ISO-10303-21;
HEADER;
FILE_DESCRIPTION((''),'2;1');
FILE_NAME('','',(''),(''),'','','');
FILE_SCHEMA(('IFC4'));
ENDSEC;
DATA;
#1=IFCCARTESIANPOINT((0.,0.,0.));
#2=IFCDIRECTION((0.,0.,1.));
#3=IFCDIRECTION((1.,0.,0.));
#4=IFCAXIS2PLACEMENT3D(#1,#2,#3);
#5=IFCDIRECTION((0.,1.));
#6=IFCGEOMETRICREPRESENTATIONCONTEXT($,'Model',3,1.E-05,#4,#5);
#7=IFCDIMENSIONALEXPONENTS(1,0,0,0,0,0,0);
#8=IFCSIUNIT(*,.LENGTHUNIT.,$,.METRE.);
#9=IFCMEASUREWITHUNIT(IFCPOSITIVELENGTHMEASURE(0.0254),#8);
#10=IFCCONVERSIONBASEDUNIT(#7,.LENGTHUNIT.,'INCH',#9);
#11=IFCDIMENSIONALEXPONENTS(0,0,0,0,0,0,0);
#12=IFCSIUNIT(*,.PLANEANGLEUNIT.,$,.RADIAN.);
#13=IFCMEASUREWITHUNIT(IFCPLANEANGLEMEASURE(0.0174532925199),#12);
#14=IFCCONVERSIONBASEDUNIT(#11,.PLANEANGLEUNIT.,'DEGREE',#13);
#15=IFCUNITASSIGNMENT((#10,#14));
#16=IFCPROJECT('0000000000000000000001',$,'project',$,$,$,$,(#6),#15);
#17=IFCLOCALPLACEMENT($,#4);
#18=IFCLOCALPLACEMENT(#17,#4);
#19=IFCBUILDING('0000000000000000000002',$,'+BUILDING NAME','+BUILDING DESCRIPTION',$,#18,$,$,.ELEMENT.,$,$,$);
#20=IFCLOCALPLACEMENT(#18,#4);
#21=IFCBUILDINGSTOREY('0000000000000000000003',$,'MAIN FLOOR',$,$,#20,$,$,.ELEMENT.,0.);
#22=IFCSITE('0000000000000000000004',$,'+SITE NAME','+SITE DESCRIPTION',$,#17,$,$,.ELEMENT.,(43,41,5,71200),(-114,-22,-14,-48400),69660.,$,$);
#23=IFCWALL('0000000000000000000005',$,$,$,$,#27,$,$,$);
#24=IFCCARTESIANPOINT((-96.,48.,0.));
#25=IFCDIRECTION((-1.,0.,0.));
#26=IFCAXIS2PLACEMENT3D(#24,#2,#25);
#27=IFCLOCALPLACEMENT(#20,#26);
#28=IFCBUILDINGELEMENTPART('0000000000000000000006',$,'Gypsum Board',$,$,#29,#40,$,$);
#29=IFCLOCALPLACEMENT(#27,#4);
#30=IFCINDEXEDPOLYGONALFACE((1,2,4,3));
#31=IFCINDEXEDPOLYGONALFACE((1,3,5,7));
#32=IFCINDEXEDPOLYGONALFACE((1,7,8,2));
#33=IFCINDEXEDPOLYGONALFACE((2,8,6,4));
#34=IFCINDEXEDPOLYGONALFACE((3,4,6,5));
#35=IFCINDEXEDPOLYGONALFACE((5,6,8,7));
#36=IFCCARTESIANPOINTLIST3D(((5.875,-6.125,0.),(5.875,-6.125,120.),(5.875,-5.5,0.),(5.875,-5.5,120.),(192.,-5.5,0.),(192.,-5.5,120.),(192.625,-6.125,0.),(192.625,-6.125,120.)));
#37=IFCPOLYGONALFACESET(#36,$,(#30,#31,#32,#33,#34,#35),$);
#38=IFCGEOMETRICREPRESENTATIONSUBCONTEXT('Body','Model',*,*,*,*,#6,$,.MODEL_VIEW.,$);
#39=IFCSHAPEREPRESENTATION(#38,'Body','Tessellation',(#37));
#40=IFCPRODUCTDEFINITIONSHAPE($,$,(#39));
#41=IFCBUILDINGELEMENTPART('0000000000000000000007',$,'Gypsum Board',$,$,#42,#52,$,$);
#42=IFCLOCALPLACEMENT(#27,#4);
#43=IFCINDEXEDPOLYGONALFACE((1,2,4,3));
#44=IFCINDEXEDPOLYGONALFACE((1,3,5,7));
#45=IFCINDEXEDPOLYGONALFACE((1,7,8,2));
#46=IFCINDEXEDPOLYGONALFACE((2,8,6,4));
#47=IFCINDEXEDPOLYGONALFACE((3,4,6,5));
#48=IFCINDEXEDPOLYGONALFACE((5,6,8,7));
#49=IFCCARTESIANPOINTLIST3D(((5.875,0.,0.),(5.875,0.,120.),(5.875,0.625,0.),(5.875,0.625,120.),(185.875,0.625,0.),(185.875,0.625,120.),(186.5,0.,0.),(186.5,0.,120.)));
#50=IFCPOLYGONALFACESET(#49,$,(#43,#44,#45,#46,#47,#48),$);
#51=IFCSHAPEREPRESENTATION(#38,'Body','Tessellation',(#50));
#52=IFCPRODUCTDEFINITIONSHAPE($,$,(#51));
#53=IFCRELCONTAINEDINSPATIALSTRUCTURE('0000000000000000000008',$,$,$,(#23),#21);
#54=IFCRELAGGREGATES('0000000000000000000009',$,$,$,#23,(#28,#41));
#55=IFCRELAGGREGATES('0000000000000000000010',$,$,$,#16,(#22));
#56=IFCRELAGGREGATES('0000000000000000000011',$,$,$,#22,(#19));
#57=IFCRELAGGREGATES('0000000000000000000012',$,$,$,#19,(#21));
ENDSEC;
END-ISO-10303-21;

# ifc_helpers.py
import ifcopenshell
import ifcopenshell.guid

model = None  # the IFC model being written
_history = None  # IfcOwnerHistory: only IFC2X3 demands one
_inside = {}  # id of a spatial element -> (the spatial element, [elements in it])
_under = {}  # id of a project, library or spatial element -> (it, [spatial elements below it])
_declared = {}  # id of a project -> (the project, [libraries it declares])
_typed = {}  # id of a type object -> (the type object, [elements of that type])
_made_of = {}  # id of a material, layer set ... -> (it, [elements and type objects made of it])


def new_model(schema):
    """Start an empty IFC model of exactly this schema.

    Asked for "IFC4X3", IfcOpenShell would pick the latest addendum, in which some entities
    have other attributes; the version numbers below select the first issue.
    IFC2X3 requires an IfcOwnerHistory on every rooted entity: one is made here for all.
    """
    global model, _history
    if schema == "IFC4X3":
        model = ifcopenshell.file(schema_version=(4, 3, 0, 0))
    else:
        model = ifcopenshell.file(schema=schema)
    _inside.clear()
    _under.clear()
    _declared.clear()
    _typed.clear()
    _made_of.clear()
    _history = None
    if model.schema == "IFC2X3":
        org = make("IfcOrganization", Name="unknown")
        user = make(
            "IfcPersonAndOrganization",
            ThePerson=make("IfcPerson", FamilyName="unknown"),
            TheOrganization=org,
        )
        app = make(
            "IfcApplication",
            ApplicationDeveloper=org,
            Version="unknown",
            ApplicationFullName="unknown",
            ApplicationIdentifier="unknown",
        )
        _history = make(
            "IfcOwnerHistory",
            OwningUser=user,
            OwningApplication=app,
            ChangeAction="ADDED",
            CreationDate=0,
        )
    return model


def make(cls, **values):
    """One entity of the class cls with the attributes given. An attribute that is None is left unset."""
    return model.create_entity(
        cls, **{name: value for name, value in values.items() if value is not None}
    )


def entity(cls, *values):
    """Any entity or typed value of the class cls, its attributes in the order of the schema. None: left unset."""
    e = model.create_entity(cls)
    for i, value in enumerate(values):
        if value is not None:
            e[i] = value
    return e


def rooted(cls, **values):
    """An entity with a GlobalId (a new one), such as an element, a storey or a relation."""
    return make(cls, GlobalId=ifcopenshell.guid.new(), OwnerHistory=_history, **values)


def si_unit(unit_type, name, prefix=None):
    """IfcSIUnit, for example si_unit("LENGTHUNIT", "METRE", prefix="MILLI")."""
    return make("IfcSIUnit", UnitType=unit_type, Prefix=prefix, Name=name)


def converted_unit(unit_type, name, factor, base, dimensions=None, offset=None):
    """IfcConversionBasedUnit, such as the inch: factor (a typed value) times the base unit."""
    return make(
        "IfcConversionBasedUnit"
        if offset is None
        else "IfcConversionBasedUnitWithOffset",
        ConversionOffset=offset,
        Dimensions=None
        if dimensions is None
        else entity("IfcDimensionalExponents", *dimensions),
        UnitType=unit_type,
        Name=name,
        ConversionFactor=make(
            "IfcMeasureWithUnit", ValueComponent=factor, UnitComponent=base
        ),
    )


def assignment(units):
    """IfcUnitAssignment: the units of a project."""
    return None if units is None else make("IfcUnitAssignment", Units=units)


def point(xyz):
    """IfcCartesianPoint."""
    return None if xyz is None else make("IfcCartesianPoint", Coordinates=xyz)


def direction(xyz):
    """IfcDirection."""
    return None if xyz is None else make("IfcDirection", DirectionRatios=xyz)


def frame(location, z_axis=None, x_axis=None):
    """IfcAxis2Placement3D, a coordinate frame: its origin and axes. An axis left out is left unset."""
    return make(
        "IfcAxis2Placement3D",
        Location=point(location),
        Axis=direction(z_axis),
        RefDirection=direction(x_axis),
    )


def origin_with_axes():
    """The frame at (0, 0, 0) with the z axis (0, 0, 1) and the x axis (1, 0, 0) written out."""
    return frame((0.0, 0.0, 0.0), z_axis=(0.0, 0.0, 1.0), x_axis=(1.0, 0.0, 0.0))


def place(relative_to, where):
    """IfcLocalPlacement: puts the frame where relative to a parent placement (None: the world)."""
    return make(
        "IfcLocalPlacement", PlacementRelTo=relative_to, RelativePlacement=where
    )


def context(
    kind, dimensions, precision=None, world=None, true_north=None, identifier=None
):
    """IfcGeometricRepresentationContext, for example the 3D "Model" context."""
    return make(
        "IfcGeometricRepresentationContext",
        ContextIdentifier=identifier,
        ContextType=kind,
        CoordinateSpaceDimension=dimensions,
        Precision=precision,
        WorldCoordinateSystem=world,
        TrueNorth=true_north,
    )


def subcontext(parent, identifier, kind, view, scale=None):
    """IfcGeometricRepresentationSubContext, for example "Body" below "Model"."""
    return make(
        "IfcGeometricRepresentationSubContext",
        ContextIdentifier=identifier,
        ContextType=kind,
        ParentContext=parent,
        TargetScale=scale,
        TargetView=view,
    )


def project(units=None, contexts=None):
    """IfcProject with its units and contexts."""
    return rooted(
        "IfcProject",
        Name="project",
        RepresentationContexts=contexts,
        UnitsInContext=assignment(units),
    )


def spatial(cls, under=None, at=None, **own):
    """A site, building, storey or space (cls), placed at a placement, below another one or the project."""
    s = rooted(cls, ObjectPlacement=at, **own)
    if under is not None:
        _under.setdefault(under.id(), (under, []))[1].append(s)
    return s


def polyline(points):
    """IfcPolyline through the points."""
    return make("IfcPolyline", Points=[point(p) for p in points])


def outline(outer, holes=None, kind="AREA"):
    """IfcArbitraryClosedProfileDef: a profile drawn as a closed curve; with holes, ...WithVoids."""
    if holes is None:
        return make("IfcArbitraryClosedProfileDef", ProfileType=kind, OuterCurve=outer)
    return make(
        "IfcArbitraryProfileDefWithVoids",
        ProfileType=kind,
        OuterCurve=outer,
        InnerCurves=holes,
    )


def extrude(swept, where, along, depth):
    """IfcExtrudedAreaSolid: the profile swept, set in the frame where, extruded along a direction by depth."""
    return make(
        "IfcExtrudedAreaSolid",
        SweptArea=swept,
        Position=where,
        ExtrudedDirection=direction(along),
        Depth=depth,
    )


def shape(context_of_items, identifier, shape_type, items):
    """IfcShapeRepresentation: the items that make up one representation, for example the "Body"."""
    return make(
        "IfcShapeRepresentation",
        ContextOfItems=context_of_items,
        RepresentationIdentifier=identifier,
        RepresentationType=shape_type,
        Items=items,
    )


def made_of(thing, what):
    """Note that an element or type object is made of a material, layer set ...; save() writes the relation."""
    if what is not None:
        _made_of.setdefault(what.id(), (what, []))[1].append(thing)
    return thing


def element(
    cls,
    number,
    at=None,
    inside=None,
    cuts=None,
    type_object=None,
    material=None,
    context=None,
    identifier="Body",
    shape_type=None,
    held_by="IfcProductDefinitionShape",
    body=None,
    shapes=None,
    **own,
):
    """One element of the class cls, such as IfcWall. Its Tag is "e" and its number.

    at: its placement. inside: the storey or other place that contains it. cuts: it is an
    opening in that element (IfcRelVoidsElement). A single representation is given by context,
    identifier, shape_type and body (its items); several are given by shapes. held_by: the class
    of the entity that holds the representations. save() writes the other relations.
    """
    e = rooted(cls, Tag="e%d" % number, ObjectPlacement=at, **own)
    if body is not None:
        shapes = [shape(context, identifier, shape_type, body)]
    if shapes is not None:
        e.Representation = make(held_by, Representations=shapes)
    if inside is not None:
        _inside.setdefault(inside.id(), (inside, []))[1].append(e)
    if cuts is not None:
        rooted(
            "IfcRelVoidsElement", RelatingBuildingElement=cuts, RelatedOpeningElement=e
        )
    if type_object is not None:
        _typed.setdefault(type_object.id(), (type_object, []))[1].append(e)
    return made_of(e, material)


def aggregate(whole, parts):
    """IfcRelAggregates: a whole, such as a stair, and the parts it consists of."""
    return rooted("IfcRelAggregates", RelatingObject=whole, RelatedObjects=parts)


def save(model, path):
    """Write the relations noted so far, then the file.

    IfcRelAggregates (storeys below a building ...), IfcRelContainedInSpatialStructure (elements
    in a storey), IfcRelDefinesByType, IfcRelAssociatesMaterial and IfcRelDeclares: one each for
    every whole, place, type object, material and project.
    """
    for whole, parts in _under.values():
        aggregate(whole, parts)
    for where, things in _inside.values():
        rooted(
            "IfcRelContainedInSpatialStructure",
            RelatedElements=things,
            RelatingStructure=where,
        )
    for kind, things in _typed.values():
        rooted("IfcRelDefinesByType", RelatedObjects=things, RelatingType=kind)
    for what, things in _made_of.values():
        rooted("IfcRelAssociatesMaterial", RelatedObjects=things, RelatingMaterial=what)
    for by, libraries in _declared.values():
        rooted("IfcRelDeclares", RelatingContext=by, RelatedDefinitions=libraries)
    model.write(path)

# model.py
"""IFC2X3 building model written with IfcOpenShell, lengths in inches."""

from ifc_helpers import new_model, entity, si_unit, converted_unit, direction, frame, origin_with_axes, place, context, subcontext, project, spatial, polyline, outline, extrude, element, aggregate, save


model = new_model("IFC2X3")

# Units and contexts
model_context = context("Model", 3, precision=1e-05, world=origin_with_axes(), true_north=direction((0.0, 1.0)))
body_context = subcontext(model_context, "Body", "Model", "MODEL_VIEW")
ifc_project = project(units=[converted_unit("LENGTHUNIT", "INCH", entity("IfcPositiveLengthMeasure", 0.0254), si_unit("LENGTHUNIT", "METRE"), dimensions=[1, 0, 0, 0, 0, 0, 0]), converted_unit("PLANEANGLEUNIT", "DEGREE", entity("IfcPlaneAngleMeasure", 0.0174532925199), si_unit("PLANEANGLEUNIT", "RADIAN"), dimensions=[0, 0, 0, 0, 0, 0, 0])], contexts=[model_context])

# Site, building, storey
site_placement = place(None, origin_with_axes())
site = spatial("IfcSite", under=ifc_project, at=site_placement, Name="+SITE NAME", Description="+SITE DESCRIPTION", CompositionType="ELEMENT", RefLatitude=(43, 41, 5, 71200), RefLongitude=(-114, -22, -14, -48400), RefElevation=69660.0)
building_placement = place(site_placement, origin_with_axes())
building = spatial("IfcBuilding", under=site, at=building_placement, Name="+BUILDING NAME", Description="+BUILDING DESCRIPTION", CompositionType="ELEMENT")
storey_placement = place(building_placement, origin_with_axes())
storey = spatial("IfcBuildingStorey", under=building, at=storey_placement, Name="MAIN FLOOR", CompositionType="ELEMENT", Elevation=0.0)

# Wall, building element parts
wall_1_placement = place(storey_placement, frame((-96.0, 48.0, 0.0), z_axis=(0.0, 0.0, 1.0), x_axis=(-1.0, 0.0, 0.0)))
wall_1 = element("IfcWall", 1, at=wall_1_placement, inside=storey)
building_element_part_1_placement = place(wall_1_placement, origin_with_axes())
building_element_part_1 = element("IfcBuildingElementPart", 2, at=building_element_part_1_placement, Name="Gypsum Board", context=body_context, shape_type="SweptSolid", body=[
    extrude(outline(polyline([(5.875, -6.125), (192.625, -6.125), (192.0, -5.5), (5.875, -5.5), (5.875, -6.125)])), origin_with_axes(), (0.0, 0.0, 1.0), 120.0),
])
building_element_part_2_placement = place(wall_1_placement, origin_with_axes())
building_element_part_2 = element("IfcBuildingElementPart", 3, at=building_element_part_2_placement, Name="Gypsum Board", context=body_context, shape_type="SweptSolid", body=[
    extrude(outline(polyline([(5.875, 0.0), (186.5, 0.0), (185.875, 0.625), (5.875, 0.625), (5.875, 0.0)])), origin_with_axes(), (0.0, 0.0, 1.0), 120.0),
])
aggregate(wall_1, [building_element_part_1, building_element_part_2])

save(model, "model.ifc")
